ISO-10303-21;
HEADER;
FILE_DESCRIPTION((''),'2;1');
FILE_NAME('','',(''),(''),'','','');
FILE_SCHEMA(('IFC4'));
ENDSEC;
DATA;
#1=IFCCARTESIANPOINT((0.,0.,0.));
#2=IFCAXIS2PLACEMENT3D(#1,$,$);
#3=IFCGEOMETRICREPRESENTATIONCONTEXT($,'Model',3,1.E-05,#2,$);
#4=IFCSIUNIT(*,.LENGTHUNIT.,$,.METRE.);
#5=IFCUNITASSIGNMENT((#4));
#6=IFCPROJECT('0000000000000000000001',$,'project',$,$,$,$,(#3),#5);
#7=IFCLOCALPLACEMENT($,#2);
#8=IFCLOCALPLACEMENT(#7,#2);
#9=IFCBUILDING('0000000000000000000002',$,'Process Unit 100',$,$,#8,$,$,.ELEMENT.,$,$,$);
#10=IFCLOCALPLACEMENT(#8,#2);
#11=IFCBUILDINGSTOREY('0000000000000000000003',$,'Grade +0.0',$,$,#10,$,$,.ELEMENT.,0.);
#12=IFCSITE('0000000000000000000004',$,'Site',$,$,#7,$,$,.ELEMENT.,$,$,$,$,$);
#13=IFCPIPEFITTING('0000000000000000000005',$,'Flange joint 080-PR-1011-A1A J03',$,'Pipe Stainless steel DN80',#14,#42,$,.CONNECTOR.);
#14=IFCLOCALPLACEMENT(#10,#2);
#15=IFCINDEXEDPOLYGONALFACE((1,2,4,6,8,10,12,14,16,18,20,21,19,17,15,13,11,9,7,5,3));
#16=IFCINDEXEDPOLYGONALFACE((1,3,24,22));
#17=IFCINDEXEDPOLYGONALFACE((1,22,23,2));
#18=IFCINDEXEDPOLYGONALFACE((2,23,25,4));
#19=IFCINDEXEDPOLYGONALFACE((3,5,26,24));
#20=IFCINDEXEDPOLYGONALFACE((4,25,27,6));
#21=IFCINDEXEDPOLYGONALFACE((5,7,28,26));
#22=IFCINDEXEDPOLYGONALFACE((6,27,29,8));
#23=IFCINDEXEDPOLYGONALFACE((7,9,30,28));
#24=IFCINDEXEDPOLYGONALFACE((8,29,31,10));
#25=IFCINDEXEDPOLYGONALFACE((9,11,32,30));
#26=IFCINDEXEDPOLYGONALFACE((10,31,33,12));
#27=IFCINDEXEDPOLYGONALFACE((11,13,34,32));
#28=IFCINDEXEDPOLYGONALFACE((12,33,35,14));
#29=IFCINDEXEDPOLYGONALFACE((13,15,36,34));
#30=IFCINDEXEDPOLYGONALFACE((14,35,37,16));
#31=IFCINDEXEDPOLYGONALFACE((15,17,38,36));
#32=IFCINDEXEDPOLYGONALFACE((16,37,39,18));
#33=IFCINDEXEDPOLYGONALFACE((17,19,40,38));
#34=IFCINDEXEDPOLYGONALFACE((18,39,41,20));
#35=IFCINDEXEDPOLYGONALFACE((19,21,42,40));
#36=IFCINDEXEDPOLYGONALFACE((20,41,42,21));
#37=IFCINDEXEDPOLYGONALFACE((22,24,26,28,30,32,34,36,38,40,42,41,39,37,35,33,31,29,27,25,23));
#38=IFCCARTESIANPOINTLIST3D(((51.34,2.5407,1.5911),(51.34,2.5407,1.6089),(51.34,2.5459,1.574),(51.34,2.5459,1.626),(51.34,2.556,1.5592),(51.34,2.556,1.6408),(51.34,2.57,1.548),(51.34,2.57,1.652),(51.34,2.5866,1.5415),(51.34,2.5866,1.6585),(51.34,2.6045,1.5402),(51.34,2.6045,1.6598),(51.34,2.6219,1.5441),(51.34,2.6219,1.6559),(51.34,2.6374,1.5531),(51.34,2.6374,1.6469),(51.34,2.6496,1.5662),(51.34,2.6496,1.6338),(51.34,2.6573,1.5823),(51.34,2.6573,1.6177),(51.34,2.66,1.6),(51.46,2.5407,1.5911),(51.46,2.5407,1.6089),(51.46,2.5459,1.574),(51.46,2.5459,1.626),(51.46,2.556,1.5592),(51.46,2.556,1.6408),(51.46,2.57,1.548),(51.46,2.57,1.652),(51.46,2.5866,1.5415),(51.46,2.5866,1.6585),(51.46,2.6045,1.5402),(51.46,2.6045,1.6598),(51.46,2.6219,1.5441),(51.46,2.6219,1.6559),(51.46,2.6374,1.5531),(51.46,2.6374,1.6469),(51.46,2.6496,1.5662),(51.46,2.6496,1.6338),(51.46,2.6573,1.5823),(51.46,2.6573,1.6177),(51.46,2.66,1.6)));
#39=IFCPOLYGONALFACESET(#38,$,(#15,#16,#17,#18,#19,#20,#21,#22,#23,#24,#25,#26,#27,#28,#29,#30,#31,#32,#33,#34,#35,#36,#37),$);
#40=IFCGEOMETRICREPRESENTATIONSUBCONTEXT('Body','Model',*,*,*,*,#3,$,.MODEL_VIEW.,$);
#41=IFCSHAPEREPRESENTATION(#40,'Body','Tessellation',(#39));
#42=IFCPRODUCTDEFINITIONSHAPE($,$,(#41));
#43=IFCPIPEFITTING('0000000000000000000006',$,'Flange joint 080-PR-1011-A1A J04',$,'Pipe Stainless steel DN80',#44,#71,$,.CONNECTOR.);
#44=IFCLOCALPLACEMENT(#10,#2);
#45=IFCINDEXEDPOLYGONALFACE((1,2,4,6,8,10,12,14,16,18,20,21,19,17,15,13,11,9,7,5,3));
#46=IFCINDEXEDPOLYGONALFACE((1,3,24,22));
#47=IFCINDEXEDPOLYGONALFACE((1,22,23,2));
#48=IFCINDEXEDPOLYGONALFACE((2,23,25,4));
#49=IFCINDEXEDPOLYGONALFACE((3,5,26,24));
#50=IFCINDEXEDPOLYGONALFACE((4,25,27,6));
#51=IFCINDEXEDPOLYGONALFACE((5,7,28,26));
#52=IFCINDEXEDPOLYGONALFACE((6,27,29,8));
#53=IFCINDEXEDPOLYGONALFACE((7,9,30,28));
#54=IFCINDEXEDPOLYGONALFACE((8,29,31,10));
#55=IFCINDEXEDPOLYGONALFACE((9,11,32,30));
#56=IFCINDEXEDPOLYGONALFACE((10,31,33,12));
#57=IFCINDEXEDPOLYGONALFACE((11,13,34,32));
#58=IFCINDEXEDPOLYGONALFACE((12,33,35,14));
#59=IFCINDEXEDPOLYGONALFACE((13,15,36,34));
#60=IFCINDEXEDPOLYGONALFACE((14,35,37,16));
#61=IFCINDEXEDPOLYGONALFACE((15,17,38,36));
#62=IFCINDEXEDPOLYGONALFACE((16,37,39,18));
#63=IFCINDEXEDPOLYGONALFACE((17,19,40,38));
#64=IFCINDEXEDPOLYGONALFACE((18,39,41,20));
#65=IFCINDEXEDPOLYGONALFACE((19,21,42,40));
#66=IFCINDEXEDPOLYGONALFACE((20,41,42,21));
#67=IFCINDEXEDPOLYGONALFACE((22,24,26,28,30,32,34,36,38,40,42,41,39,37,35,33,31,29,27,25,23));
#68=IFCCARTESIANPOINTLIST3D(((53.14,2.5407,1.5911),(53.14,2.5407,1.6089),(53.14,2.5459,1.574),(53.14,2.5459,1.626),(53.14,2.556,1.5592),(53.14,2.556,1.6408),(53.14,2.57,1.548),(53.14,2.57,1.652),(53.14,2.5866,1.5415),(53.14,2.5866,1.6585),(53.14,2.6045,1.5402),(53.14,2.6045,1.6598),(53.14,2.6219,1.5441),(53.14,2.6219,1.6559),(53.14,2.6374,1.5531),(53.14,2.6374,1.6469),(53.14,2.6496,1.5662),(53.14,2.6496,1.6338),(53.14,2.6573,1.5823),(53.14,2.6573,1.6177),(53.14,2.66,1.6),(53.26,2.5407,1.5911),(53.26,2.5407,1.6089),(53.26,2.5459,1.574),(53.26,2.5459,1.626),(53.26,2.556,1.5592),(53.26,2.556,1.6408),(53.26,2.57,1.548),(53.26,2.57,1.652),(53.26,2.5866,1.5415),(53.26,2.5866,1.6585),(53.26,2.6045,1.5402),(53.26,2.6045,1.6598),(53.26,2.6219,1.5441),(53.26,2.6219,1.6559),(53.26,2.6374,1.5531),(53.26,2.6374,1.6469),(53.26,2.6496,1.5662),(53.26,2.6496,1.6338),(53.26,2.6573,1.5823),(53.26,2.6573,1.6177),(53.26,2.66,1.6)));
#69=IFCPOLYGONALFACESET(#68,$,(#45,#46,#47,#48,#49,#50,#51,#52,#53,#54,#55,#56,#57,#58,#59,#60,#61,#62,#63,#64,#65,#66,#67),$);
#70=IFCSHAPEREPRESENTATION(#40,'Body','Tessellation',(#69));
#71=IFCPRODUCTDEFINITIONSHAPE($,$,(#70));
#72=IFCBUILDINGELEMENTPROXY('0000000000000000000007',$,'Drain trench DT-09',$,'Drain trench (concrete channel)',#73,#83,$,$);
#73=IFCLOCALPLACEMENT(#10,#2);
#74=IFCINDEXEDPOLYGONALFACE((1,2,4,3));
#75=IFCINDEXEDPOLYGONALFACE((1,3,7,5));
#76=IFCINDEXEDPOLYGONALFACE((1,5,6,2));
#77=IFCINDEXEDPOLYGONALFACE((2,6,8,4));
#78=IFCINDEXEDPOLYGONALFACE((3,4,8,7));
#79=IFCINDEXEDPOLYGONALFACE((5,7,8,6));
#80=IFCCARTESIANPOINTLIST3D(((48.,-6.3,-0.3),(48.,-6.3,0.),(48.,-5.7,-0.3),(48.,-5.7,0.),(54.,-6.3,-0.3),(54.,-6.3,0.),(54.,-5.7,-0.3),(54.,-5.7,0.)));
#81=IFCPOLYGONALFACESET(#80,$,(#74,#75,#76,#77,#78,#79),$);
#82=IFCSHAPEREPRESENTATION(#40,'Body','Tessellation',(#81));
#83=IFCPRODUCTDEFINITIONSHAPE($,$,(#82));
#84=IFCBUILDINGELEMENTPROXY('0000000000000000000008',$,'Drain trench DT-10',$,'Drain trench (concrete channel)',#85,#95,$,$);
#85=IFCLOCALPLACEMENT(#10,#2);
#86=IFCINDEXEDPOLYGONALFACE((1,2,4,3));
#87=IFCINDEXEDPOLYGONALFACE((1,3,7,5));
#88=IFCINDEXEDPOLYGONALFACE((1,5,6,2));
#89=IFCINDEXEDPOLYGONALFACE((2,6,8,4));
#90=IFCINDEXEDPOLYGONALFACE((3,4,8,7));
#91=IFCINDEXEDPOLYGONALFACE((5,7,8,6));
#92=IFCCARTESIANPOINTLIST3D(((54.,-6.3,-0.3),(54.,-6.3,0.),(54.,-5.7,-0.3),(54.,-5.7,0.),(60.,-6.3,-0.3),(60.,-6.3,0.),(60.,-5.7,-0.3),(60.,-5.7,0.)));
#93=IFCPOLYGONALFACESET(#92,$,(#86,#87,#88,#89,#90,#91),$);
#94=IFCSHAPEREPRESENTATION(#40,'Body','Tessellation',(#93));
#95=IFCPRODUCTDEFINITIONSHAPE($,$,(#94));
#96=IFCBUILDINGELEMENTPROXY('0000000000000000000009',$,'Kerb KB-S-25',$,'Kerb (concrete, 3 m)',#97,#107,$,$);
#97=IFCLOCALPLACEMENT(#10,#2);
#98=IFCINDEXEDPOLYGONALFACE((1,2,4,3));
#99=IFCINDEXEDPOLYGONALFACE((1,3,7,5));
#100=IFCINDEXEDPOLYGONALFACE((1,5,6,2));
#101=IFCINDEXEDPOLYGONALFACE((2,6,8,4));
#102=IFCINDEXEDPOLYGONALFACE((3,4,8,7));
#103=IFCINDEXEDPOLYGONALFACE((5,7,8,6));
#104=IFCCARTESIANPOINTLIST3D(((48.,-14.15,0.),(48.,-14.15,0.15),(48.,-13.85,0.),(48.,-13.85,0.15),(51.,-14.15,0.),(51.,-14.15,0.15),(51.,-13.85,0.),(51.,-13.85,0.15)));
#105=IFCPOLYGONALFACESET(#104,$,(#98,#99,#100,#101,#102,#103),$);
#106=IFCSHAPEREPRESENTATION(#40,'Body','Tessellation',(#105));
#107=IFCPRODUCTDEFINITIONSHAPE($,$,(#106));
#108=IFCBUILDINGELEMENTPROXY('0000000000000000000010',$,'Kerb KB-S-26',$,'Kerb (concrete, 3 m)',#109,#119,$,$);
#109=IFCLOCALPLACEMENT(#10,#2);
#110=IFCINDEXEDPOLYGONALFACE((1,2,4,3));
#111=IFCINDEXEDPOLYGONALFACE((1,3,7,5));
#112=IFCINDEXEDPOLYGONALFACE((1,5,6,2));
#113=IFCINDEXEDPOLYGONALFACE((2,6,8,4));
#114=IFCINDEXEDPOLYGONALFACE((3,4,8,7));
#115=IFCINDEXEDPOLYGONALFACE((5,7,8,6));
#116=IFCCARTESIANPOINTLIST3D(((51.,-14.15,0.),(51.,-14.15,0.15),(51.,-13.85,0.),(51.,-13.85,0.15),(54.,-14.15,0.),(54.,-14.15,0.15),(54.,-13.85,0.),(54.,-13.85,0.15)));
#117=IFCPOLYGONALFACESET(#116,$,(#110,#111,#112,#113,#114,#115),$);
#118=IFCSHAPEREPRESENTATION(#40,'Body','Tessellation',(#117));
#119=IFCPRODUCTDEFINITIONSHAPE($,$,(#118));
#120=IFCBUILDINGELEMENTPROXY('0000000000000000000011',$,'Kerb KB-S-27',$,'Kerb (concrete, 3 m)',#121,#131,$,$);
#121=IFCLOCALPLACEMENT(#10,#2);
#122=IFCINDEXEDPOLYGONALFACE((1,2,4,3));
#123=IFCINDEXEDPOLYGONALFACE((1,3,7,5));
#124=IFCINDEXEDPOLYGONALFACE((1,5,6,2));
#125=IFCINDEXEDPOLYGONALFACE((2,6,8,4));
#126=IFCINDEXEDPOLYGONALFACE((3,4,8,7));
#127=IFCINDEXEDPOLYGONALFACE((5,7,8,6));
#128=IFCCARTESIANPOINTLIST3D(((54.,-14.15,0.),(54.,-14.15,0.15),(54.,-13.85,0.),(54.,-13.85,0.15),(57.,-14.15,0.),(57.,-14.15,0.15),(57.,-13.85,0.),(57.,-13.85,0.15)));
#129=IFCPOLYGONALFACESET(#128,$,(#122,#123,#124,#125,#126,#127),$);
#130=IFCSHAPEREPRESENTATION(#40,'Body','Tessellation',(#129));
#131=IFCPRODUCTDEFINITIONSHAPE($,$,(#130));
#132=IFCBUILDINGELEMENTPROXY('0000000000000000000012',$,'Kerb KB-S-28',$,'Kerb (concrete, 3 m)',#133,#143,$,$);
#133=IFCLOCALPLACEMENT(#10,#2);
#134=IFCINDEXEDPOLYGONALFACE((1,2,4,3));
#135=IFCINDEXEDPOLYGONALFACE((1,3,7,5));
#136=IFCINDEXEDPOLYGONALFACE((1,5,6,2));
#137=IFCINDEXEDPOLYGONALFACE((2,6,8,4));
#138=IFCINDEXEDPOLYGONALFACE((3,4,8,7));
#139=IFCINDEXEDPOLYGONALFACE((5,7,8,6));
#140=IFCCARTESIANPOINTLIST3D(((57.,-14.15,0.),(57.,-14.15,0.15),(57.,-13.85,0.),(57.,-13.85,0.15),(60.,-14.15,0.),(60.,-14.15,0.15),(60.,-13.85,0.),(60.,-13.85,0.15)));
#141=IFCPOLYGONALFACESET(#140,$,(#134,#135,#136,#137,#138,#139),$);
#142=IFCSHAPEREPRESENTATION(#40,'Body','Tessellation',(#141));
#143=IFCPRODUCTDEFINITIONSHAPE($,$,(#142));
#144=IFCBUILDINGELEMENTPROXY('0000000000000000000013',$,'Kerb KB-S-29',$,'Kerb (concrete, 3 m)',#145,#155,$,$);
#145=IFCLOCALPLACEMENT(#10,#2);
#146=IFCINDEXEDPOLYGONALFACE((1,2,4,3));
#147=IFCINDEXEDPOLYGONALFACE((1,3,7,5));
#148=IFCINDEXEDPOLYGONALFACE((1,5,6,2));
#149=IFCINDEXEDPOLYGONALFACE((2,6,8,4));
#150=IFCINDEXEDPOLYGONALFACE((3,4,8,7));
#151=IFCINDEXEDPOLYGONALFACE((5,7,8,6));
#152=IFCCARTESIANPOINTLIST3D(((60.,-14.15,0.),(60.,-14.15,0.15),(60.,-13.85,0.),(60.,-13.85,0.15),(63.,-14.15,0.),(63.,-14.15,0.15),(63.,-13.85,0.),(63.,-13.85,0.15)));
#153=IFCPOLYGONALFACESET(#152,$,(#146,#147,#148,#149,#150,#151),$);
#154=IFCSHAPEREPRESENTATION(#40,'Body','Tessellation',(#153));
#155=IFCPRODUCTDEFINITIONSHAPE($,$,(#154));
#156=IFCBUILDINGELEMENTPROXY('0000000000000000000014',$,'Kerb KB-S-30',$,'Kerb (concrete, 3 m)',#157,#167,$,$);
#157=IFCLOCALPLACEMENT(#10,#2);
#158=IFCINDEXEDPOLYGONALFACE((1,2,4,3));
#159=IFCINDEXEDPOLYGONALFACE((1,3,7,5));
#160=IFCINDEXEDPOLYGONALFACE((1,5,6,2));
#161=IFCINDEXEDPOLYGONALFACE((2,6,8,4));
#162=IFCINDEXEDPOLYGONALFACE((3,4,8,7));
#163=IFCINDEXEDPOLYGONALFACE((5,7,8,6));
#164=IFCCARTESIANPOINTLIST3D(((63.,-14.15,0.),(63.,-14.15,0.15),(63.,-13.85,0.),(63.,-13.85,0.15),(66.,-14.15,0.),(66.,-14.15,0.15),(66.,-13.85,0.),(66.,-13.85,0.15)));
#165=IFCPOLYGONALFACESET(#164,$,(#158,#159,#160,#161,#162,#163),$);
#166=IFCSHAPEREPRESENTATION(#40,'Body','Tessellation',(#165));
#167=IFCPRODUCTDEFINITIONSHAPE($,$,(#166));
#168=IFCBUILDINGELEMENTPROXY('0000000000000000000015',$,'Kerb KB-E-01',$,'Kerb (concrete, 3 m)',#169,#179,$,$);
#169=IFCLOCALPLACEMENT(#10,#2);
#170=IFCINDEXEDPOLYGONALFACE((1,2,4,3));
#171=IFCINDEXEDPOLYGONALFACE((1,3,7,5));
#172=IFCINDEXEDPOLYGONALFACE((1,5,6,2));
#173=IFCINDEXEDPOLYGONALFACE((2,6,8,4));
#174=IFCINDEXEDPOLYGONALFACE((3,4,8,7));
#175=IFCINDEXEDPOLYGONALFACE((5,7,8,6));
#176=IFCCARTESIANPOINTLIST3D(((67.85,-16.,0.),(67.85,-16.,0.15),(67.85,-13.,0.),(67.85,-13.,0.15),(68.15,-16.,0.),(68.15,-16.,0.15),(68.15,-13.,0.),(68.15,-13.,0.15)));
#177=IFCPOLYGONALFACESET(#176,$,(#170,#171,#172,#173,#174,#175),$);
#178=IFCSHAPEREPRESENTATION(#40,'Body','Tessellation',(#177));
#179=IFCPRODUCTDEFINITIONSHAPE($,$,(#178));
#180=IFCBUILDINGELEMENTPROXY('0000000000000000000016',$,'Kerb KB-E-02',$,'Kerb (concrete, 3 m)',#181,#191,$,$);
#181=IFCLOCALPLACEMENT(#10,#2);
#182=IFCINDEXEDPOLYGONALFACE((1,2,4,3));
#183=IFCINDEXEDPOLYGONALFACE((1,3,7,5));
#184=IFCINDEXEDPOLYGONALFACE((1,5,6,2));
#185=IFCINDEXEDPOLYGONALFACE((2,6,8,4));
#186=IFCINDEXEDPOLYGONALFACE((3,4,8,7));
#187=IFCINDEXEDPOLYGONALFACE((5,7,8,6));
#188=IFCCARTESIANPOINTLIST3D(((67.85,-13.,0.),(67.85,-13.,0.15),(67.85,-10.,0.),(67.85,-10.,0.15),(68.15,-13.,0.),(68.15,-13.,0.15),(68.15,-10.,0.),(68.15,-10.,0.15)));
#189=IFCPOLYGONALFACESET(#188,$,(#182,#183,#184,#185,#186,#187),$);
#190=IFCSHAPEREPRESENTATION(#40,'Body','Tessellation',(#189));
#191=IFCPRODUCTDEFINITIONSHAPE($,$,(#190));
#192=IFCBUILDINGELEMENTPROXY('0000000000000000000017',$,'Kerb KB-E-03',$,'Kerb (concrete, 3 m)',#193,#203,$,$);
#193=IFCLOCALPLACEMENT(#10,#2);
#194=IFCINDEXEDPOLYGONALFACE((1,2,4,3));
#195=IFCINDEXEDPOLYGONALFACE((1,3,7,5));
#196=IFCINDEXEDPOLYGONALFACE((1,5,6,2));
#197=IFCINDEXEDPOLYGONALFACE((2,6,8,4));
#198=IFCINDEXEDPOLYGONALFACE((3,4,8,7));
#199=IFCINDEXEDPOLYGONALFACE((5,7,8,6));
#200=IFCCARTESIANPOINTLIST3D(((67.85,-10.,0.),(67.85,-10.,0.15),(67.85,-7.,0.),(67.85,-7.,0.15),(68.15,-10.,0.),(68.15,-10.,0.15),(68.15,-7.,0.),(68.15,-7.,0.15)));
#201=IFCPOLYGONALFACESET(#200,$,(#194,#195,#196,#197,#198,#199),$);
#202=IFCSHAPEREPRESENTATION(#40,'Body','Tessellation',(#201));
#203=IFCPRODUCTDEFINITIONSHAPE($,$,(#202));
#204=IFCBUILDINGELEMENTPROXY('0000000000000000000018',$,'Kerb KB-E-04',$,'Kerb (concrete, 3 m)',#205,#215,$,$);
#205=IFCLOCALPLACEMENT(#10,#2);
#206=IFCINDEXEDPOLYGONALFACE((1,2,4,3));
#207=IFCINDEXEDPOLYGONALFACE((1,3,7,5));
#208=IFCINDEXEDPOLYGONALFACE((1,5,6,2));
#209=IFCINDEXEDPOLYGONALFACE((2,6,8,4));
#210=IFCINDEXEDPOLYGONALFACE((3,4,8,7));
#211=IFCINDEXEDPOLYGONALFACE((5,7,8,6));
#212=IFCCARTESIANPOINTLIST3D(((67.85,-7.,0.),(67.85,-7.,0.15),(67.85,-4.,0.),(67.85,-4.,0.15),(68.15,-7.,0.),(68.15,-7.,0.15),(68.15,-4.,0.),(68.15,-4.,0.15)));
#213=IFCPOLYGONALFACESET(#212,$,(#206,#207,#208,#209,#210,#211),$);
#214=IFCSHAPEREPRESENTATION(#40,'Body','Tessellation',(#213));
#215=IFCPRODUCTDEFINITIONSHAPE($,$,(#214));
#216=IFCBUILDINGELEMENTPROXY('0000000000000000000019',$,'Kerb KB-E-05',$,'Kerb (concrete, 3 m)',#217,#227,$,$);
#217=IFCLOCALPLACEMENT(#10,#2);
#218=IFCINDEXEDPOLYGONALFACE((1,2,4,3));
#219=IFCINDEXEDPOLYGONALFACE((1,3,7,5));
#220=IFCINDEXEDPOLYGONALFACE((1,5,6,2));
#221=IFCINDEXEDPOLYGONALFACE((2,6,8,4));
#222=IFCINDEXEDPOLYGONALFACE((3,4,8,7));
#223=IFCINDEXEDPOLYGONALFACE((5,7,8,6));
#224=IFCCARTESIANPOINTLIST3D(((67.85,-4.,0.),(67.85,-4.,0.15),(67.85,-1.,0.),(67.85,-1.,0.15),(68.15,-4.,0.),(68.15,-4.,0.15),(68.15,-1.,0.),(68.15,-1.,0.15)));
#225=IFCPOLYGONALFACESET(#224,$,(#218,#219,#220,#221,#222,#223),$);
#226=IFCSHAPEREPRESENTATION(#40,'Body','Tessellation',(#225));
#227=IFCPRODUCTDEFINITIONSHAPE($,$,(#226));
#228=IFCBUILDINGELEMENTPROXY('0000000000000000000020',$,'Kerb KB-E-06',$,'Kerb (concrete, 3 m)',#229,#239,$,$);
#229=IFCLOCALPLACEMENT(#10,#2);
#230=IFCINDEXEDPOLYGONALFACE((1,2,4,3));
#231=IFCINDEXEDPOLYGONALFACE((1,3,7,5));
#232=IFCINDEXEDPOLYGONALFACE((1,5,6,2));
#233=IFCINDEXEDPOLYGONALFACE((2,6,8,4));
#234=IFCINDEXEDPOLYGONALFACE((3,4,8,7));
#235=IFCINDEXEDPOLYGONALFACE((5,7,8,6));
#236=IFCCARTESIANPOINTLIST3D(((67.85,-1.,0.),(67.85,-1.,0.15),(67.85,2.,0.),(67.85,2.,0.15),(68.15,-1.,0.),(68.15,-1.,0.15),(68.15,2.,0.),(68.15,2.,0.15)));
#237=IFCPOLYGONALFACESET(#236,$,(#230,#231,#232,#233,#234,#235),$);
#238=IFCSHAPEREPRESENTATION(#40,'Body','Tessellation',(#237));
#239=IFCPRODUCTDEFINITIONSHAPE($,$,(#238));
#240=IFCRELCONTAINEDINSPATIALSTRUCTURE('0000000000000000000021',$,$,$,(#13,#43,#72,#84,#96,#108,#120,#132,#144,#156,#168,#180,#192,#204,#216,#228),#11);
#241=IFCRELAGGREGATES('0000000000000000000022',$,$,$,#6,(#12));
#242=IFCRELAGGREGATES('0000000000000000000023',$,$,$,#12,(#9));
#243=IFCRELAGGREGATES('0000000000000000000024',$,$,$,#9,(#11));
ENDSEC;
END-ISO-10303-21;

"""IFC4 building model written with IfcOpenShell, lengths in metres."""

from ifc_helpers import new_model, si_unit, frame, origin, place, context, subcontext, project, spatial, rectangle, circle, extrude, element, save


model = new_model("IFC4")

# Units and contexts
model_context = context("Model", 3, precision=1e-05, world=origin())
body_context = subcontext(model_context, "Body", "Model", "MODEL_VIEW")
ifc_project = project(units=[si_unit("LENGTHUNIT", "METRE")], contexts=[model_context])

# Site, building, storey
site_placement = place(None, origin())
site = spatial("IfcSite", under=ifc_project, at=site_placement, Name="Site", CompositionType="ELEMENT")
building_placement = place(site_placement, origin())
building = spatial("IfcBuilding", under=site, at=building_placement, Name="Process Unit 100", CompositionType="ELEMENT")
storey_placement = place(building_placement, origin())
storey = spatial("IfcBuildingStorey", under=building, at=storey_placement, Name="Grade +0.0", CompositionType="ELEMENT", Elevation=0.0)

# Pipe fittings
for number, where, z_axis, x_axis, name in (
    (1, (51.34, 2.6, 1.6), (1.0, 0.0, 0.0), (0.0, 1.0, 0.0), "Flange joint 080-PR-1011-A1A J03"),
    (2, (53.14, 2.6, 1.6), (1.0, 0.0, 0.0), (0.0, 1.0, 0.0), "Flange joint 080-PR-1011-A1A J04"),
):
    element("IfcPipeFitting", number, at=place(storey_placement, frame(where, z_axis=z_axis, x_axis=x_axis)), inside=storey, Name=name, ObjectType="Pipe Stainless steel DN80", PredefinedType="CONNECTOR", context=body_context, shape_type="SweptSolid", body=[
        extrude(circle(Radius=0.06), origin(), (0.0, 0.0, 1.0), 0.12),
    ])

# Building element proxies
for number, where, z_axis, x_axis, name in (
    (3, (51.0, -6.0, -0.3), (0.0, 0.0, 1.0), (1.0, 0.0, 0.0), "Drain trench DT-09"),
    (4, (57.0, -6.0, -0.3), (0.0, 0.0, 1.0), (1.0, 0.0, 0.0), "Drain trench DT-10"),
):
    element("IfcBuildingElementProxy", number, at=place(storey_placement, frame(where, z_axis=z_axis, x_axis=x_axis)), inside=storey, Name=name, ObjectType="Drain trench (concrete channel)", context=body_context, shape_type="SweptSolid", body=[
        extrude(rectangle(XDim=6.0, YDim=0.6), origin(), (0.0, 0.0, 1.0), 0.3),
    ])
for number, where, z_axis, x_axis, name in (
    (5, (49.5, -14.0, 0.0), (0.0, 0.0, 1.0), (1.0, 0.0, 0.0), "Kerb KB-S-25"),
    (6, (52.5, -14.0, 0.0), (0.0, 0.0, 1.0), (1.0, 0.0, 0.0), "Kerb KB-S-26"),
    (7, (55.5, -14.0, 0.0), (0.0, 0.0, 1.0), (1.0, 0.0, 0.0), "Kerb KB-S-27"),
    (8, (58.5, -14.0, 0.0), (0.0, 0.0, 1.0), (1.0, 0.0, 0.0), "Kerb KB-S-28"),
    (9, (61.5, -14.0, 0.0), (0.0, 0.0, 1.0), (1.0, 0.0, 0.0), "Kerb KB-S-29"),
    (10, (64.5, -14.0, 0.0), (0.0, 0.0, 1.0), (1.0, 0.0, 0.0), "Kerb KB-S-30"),
):
    element("IfcBuildingElementProxy", number, at=place(storey_placement, frame(where, z_axis=z_axis, x_axis=x_axis)), inside=storey, Name=name, ObjectType="Kerb (concrete, 3 m)", context=body_context, shape_type="SweptSolid", body=[
        extrude(rectangle(XDim=3.0, YDim=0.3), origin(), (0.0, 0.0, 1.0), 0.15),
    ])
for number, where, z_axis, x_axis, name in (
    (11, (68.0, -14.5, 0.0), (0.0, 0.0, 1.0), (1.0, 0.0, 0.0), "Kerb KB-E-01"),
    (12, (68.0, -11.5, 0.0), (0.0, 0.0, 1.0), (1.0, 0.0, 0.0), "Kerb KB-E-02"),
    (13, (68.0, -8.5, 0.0), (0.0, 0.0, 1.0), (1.0, 0.0, 0.0), "Kerb KB-E-03"),
    (14, (68.0, -5.5, 0.0), (0.0, 0.0, 1.0), (1.0, 0.0, 0.0), "Kerb KB-E-04"),
    (15, (68.0, -2.5, 0.0), (0.0, 0.0, 1.0), (1.0, 0.0, 0.0), "Kerb KB-E-05"),
    (16, (68.0, 0.5, 0.0), (0.0, 0.0, 1.0), (1.0, 0.0, 0.0), "Kerb KB-E-06"),
):
    element("IfcBuildingElementProxy", number, at=place(storey_placement, frame(where, z_axis=z_axis, x_axis=x_axis)), inside=storey, Name=name, ObjectType="Kerb (concrete, 3 m)", context=body_context, shape_type="SweptSolid", body=[
        extrude(rectangle(XDim=0.3, YDim=3.0), origin(), (0.0, 0.0, 1.0), 0.15),
    ])

save(model, "model.ifc")
